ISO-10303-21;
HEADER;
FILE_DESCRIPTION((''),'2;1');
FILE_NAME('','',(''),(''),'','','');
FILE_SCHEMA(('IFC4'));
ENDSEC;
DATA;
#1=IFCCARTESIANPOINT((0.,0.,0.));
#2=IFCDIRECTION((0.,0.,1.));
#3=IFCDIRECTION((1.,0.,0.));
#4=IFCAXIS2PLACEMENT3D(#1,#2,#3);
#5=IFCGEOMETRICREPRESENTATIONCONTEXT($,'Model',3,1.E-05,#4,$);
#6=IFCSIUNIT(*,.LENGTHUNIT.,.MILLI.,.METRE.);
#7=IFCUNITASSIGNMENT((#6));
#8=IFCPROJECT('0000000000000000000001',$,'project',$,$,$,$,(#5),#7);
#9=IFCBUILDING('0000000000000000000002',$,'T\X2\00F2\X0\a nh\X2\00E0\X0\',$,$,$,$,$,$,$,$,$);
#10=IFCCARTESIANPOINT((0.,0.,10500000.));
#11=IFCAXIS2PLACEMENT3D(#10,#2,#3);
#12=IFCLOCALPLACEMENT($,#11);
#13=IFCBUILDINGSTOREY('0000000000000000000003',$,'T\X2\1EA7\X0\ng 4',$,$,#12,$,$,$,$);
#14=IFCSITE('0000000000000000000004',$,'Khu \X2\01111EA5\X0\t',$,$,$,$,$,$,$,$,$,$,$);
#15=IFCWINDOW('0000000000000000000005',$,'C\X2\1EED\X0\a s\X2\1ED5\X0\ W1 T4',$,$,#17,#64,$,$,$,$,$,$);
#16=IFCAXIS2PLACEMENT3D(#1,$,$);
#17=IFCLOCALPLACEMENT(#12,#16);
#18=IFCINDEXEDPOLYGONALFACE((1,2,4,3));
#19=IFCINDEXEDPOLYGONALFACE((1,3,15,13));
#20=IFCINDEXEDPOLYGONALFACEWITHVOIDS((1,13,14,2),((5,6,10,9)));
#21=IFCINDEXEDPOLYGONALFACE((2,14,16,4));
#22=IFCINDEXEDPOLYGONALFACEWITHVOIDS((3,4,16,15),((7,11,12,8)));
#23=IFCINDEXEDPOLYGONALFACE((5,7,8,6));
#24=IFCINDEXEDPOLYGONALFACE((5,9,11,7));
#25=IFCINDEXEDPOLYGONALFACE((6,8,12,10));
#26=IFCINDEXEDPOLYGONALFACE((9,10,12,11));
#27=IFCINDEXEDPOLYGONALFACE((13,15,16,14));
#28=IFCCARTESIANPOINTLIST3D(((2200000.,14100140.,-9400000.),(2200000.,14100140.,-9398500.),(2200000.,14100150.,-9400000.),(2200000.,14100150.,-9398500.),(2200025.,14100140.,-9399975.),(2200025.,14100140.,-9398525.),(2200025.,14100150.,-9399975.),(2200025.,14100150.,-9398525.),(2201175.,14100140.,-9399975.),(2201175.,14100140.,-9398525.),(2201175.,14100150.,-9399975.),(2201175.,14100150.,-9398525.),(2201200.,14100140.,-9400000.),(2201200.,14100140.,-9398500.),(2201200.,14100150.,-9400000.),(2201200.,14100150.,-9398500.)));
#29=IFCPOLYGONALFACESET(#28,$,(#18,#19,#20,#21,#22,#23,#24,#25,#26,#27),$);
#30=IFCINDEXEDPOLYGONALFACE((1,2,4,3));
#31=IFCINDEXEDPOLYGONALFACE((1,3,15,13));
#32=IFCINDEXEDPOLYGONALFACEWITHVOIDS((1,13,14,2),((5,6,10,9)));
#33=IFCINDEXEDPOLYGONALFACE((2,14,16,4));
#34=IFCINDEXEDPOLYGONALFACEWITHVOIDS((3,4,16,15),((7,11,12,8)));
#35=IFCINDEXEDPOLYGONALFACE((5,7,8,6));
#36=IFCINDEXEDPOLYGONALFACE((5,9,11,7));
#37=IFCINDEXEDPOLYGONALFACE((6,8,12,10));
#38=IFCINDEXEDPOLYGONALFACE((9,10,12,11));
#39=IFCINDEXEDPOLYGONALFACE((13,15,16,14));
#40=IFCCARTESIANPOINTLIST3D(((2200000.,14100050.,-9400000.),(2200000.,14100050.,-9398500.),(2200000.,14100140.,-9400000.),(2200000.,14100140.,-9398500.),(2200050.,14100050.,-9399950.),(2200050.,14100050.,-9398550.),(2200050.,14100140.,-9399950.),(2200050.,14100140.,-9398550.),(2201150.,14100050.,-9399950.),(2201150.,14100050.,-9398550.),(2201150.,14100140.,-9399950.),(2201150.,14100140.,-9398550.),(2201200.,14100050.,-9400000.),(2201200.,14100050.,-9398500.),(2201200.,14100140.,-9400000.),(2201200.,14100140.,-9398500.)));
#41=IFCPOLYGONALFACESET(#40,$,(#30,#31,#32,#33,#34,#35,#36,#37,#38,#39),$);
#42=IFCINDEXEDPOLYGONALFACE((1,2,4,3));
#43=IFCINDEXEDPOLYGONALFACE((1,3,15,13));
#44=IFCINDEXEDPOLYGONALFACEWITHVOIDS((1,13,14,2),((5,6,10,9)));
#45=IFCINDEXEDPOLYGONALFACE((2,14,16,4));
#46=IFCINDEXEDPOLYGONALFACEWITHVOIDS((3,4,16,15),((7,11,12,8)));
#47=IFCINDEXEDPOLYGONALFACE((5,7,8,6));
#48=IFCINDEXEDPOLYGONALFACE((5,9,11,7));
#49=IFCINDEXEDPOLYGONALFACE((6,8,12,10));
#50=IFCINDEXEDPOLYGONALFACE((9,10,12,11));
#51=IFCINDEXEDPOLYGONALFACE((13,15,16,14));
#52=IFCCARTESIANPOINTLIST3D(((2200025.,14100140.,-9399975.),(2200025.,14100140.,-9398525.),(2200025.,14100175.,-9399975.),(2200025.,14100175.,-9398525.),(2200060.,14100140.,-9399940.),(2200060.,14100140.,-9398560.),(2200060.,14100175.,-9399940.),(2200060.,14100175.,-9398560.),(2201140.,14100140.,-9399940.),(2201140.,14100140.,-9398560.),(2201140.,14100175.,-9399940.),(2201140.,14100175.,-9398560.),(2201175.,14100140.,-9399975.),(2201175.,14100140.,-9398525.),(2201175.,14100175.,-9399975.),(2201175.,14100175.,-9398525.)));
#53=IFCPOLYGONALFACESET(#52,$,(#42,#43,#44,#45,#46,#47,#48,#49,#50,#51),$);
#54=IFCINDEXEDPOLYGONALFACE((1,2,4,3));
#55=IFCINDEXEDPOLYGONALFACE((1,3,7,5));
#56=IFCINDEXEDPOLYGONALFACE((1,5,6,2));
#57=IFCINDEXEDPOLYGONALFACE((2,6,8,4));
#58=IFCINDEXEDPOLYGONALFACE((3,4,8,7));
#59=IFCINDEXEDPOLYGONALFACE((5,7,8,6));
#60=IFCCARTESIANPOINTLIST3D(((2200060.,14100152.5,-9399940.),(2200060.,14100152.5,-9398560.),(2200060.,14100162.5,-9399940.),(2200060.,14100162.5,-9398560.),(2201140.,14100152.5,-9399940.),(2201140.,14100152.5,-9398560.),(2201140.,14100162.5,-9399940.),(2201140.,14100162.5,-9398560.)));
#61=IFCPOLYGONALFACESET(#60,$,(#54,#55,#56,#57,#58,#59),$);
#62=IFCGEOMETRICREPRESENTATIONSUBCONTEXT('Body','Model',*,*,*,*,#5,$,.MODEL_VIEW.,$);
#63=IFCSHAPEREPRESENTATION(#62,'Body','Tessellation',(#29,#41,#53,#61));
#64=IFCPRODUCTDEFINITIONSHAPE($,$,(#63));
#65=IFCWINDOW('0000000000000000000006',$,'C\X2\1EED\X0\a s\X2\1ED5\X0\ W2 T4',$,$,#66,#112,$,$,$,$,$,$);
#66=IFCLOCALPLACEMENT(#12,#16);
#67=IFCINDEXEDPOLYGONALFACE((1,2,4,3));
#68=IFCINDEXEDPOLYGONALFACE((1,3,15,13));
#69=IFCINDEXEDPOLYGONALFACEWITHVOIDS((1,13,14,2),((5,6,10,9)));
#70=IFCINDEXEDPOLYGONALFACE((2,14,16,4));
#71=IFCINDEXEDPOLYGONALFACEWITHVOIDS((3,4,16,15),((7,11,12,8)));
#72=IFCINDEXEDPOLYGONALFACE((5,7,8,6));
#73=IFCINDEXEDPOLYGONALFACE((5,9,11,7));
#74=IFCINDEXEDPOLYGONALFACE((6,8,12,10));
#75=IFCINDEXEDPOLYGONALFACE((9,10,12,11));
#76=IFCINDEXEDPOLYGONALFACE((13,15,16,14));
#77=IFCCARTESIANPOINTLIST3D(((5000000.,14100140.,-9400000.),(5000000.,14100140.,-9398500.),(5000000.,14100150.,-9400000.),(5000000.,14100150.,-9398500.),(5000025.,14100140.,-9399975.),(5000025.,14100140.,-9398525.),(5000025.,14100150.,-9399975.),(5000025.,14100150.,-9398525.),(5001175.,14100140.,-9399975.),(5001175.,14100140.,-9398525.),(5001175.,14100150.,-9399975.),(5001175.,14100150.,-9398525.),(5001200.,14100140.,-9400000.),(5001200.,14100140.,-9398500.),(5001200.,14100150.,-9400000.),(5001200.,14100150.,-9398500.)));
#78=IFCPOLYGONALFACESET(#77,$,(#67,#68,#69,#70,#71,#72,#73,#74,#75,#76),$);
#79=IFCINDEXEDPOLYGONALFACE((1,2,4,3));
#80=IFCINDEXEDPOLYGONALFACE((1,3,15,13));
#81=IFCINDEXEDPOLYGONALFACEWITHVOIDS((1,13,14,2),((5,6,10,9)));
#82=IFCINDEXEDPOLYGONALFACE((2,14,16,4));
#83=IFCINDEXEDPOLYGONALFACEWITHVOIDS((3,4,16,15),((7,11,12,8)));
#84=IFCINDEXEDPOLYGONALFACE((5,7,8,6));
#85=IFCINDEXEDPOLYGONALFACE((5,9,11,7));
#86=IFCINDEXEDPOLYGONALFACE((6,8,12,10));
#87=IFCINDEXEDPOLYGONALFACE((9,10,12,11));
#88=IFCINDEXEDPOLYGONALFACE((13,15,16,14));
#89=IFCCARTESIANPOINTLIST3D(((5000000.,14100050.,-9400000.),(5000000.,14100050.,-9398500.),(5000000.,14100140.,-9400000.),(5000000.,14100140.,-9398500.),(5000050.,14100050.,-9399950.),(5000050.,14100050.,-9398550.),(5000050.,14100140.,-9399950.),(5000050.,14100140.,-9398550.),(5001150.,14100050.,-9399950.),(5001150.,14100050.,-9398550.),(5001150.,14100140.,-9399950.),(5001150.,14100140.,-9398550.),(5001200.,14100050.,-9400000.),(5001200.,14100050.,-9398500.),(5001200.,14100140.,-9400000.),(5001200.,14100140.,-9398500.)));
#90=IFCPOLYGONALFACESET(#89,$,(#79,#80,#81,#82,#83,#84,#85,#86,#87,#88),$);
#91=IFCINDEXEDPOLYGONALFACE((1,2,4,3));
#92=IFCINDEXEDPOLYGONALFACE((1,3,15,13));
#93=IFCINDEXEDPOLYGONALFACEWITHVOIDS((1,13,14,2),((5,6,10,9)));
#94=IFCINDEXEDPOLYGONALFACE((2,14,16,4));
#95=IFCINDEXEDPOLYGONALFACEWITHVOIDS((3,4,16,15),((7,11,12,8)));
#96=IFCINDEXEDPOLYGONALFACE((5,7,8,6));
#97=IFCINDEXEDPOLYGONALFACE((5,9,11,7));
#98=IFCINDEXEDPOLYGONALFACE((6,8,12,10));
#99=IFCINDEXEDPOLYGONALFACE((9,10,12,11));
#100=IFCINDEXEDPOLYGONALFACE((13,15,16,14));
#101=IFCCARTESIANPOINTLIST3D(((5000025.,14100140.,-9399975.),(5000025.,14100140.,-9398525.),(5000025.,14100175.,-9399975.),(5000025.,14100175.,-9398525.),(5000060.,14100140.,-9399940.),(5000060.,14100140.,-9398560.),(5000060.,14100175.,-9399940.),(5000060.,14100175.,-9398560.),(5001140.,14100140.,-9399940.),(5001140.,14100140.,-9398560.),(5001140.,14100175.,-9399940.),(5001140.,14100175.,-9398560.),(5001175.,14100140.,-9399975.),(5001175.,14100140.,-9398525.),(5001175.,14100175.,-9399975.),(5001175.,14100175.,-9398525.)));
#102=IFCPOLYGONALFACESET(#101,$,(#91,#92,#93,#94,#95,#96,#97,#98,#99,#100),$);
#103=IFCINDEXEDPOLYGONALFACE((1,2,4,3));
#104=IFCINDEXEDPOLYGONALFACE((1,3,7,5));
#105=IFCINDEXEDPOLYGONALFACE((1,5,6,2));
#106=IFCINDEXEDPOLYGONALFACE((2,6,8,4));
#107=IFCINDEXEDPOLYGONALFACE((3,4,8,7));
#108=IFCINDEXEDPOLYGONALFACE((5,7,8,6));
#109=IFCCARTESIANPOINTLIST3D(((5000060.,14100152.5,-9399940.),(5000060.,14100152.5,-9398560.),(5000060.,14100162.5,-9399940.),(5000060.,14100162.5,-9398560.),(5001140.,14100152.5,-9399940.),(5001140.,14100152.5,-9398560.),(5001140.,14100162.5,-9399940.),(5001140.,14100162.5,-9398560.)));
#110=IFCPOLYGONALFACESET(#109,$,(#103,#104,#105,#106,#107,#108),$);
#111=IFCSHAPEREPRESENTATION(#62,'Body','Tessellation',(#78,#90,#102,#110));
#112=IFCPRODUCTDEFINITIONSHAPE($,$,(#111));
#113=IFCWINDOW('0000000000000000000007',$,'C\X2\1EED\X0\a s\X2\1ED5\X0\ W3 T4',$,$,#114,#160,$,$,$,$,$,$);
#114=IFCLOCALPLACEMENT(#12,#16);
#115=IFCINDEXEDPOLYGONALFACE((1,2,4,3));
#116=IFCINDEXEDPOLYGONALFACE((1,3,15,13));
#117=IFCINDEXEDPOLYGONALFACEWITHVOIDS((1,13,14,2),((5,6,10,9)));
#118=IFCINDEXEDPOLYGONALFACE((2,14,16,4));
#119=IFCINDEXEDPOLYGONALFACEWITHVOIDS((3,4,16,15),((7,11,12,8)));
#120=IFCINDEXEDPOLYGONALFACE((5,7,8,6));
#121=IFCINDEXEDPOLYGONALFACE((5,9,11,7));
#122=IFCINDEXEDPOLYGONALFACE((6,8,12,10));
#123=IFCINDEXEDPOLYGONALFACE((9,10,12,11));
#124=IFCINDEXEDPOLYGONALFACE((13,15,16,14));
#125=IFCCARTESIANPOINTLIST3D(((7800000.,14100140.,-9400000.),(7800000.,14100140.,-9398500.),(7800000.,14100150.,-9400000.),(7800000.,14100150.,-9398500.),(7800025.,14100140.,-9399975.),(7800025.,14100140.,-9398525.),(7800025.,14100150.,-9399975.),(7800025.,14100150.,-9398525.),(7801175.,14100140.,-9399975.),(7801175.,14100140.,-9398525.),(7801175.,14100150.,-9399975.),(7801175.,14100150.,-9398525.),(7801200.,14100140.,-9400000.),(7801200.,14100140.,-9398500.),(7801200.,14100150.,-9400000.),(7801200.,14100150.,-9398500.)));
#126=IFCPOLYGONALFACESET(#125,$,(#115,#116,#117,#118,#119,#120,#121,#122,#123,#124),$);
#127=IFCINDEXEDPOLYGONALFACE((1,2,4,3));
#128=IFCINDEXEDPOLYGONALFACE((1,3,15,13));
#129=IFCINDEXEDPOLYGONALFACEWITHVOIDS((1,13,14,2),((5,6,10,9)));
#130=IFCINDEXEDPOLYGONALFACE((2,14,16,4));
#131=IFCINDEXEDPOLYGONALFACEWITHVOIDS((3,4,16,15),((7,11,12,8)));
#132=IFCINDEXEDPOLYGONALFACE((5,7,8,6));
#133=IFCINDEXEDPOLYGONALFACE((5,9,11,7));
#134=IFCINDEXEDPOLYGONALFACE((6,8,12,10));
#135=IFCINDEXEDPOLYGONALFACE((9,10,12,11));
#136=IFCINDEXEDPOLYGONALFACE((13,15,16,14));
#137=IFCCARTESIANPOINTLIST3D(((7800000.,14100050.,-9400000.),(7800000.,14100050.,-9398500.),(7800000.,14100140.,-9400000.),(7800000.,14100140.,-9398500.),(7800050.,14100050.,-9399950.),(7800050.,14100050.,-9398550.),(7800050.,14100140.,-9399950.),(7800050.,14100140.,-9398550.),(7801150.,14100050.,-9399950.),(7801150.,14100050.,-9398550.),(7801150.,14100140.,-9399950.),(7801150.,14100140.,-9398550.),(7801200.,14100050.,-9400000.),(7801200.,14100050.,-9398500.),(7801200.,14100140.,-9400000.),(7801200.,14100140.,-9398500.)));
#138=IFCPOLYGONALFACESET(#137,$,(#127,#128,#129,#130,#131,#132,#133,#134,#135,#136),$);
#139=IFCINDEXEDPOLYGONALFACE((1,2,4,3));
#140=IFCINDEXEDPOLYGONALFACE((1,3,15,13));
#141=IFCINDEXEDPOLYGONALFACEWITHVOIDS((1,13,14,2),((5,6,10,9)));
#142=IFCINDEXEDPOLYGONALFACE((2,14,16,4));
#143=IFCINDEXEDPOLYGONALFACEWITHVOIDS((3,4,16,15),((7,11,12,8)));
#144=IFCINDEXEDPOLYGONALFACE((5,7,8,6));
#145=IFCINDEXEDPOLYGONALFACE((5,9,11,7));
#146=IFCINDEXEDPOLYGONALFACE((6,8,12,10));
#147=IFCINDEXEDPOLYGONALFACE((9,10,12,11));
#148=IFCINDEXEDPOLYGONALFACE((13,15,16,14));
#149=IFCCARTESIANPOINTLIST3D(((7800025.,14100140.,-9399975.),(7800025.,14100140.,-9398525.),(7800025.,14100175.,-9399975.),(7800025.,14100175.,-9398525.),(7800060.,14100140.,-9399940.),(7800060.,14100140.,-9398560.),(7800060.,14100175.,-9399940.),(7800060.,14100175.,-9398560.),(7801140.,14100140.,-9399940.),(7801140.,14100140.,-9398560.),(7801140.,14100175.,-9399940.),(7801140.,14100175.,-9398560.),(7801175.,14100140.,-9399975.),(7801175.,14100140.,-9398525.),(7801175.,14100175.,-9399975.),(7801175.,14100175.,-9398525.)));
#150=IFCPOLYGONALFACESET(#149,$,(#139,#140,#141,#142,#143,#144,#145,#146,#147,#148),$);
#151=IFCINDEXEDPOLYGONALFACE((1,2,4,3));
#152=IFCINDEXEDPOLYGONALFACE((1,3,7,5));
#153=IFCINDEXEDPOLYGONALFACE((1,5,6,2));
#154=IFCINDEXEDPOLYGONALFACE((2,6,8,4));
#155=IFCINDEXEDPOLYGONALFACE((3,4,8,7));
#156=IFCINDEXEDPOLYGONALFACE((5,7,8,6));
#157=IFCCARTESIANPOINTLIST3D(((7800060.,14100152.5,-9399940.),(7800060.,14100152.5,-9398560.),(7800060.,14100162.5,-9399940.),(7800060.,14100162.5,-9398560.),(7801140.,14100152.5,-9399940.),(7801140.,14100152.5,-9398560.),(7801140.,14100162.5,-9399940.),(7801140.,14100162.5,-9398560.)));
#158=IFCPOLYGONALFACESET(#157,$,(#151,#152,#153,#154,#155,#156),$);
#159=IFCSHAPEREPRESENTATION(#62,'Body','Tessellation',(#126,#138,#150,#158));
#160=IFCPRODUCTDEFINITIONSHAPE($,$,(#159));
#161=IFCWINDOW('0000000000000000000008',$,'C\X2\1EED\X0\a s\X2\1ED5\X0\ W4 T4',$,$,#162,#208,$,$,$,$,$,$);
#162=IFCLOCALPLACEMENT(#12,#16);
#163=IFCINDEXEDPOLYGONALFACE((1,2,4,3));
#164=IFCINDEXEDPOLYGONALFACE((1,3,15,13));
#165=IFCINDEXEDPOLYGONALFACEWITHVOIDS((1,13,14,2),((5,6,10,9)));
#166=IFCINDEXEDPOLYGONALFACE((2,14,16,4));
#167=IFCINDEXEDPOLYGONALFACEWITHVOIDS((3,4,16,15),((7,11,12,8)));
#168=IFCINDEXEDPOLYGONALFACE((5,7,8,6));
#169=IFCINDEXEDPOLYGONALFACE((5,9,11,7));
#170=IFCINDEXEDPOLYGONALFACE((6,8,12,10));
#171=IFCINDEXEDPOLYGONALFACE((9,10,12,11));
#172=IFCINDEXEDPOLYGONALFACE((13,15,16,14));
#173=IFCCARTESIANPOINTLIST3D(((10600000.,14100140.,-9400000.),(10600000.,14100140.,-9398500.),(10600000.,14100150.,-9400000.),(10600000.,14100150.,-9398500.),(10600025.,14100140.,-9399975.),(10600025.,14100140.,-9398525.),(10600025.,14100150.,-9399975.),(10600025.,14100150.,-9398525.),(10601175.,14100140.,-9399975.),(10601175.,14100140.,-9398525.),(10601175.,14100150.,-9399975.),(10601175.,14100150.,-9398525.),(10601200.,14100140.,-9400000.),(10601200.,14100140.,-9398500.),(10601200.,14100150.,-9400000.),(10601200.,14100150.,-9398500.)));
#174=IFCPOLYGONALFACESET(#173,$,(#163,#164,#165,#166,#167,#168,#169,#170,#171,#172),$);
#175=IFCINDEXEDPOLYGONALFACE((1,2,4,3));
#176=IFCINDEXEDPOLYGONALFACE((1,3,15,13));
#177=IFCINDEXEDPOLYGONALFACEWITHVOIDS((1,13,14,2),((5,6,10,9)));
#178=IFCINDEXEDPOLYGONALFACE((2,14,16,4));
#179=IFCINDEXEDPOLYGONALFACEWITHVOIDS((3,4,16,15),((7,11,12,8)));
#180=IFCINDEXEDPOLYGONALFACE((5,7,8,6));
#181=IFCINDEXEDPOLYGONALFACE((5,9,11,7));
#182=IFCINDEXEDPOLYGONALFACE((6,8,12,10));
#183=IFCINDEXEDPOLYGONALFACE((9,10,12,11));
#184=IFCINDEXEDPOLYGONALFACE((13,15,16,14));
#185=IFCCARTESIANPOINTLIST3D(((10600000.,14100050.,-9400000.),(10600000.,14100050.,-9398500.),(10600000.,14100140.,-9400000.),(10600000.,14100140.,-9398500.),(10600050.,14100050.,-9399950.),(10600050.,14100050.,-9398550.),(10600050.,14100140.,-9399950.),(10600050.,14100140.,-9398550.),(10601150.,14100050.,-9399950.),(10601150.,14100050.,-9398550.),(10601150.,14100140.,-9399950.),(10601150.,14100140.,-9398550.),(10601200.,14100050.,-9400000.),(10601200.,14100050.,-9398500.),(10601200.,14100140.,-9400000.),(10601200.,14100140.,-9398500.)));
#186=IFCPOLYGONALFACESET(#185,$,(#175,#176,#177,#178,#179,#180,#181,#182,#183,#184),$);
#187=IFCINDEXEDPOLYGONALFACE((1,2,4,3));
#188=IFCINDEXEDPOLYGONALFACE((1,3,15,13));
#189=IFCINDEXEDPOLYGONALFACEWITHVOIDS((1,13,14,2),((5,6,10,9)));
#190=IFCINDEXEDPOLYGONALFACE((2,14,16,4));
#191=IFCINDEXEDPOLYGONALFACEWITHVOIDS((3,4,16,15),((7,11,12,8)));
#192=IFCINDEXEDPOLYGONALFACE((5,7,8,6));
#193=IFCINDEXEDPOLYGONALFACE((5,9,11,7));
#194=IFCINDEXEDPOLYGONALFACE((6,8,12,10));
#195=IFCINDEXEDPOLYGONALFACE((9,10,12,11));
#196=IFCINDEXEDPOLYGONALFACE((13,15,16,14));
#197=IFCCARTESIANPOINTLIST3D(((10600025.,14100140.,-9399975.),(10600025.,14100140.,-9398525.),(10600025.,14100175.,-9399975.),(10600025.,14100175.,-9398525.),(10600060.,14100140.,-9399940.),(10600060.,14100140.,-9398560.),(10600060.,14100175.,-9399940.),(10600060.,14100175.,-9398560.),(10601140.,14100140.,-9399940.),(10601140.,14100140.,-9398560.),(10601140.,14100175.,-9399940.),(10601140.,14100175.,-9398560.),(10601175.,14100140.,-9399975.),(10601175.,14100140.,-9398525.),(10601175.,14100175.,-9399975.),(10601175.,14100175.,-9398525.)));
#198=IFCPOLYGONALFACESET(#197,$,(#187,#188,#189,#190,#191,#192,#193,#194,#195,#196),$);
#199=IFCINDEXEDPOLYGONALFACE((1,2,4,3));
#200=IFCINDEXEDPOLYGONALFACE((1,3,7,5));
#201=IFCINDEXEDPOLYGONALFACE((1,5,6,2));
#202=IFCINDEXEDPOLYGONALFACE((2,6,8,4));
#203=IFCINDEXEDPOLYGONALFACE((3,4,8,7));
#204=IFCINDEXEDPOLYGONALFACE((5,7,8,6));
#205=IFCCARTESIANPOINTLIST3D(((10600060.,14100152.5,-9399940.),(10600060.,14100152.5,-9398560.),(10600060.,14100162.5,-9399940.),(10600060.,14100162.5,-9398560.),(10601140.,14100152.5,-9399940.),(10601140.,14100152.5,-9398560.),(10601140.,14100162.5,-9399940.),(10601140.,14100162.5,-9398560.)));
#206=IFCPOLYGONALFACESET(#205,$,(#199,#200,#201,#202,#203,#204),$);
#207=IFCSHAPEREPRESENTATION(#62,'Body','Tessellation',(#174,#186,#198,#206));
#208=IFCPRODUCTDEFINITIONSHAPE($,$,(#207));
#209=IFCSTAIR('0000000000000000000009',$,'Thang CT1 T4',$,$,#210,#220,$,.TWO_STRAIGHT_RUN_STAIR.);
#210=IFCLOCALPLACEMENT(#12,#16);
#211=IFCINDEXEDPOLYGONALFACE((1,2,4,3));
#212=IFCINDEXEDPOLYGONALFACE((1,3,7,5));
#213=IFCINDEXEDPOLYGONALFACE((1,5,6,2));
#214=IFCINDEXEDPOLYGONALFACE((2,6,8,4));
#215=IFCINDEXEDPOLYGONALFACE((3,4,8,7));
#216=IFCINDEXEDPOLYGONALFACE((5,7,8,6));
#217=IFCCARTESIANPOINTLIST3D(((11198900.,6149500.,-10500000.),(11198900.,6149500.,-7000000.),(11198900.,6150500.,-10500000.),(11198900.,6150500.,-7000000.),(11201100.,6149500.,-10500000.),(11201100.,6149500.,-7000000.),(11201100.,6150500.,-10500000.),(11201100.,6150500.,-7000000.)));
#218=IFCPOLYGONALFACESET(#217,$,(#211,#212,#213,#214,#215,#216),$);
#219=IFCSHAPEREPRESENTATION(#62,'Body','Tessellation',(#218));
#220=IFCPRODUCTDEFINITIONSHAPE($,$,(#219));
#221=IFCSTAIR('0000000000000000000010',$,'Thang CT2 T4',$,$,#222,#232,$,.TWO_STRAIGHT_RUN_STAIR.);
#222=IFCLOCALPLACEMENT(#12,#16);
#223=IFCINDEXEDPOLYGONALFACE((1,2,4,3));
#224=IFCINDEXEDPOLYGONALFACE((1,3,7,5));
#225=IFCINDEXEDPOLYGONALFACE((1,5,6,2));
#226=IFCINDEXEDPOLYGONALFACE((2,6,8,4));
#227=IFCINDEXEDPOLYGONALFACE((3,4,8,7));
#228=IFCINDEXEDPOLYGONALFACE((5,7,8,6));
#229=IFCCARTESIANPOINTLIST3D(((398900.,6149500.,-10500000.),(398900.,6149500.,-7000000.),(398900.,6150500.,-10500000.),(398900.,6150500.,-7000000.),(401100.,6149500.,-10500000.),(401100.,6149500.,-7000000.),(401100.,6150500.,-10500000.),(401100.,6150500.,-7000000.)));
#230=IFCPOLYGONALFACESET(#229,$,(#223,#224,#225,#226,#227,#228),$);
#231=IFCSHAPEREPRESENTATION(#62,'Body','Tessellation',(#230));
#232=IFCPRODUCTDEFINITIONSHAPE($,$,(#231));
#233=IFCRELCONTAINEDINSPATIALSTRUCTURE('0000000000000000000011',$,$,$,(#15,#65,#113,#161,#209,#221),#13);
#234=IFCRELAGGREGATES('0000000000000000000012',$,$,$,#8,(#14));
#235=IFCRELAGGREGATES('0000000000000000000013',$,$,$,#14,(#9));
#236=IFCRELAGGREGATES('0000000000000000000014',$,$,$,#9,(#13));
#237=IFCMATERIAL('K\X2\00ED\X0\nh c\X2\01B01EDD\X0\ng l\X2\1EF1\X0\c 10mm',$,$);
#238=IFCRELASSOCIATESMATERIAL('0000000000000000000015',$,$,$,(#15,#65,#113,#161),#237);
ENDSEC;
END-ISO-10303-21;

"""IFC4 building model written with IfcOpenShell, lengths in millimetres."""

from ifc_helpers import new_model, entity, si_unit, frame, origin_with_axes, place, context, subcontext, project, spatial, line, indexed_curve, outline, extrude, material, element, save


model = new_model("IFC4")

# Units and contexts
model_context = context("Model", 3, precision=1e-05, world=origin_with_axes())
body_context = subcontext(model_context, "Body", "Model", "MODEL_VIEW")
ifc_project = project(units=[si_unit("LENGTHUNIT", "METRE", prefix="MILLI")], contexts=[model_context])

# Site, building, storey
site = spatial("IfcSite", under=ifc_project, Name="Khu đất")
building = spatial("IfcBuilding", under=site, Name="Tòa nhà")
storey_placement = place(None, frame((0.0, 0.0, 10500000.0), z_axis=(0.0, 0.0, 1.0), x_axis=(1.0, 0.0, 0.0)))
storey = spatial("IfcBuildingStorey", under=building, at=storey_placement, Name="Tầng 4")

# Windows
ifc_material_1 = material(Name="Kính cường lực 10mm")
for number, where, z_axis, x_axis, name in (
    (1, (2200000.0, 14100000.0, -9400000.0), (0.0, 0.0, 1.0), (1.0, 0.0, 0.0), "Cửa sổ W1 T4"),
    (2, (5000000.0, 14100000.0, -9400000.0), (0.0, 0.0, 1.0), (1.0, 0.0, 0.0), "Cửa sổ W2 T4"),
    (3, (7800000.0, 14100000.0, -9400000.0), (0.0, 0.0, 1.0), (1.0, 0.0, 0.0), "Cửa sổ W3 T4"),
    (4, (10600000.0, 14100000.0, -9400000.0), (0.0, 0.0, 1.0), (1.0, 0.0, 0.0), "Cửa sổ W4 T4"),
):
    element("IfcWindow", number, at=place(storey_placement, frame(where, z_axis=z_axis, x_axis=x_axis)), inside=storey, material=ifc_material_1, Name=name, context=body_context, shape_type="SolidModel", body=[
        extrude(outline(indexed_curve([(0.0, 0.0), (1200.0, 0.0), (1200.0, 1500.0), (0.0, 1500.0)], segments=[line(1, 2, 3, 4, 1)]), holes=[indexed_curve([(25.0, 25.0), (1175.0, 25.0), (1175.0, 1475.0), (25.0, 1475.0)], segments=[line(1, 2, 3, 4, 1)])]), frame((0.0, 140.0, 0.0), z_axis=(0.0, -1.0, 0.0), x_axis=(1.0, 0.0, 0.0)), (0.0, 0.0, -1.0), 10.0),
        extrude(outline(indexed_curve([(0.0, 0.0), (1200.0, 0.0), (1200.0, 1500.0), (0.0, 1500.0)], segments=[line(1, 2, 3, 4, 1)]), holes=[indexed_curve([(50.0, 50.0), (1150.0, 50.0), (1150.0, 1450.0), (50.0, 1450.0)], segments=[line(1, 2, 3, 4, 1)])]), frame((0.0, 50.0, 0.0), z_axis=(0.0, -1.0, 0.0), x_axis=(1.0, 0.0, 0.0)), (0.0, 0.0, -1.0), 90.0),
        extrude(outline(indexed_curve([(0.0, 0.0), (1150.0, 0.0), (1150.0, 1450.0), (0.0, 1450.0)], segments=[line(1, 2, 3, 4, 1)]), holes=[indexed_curve([(35.0, 35.0), (1115.0, 35.0), (1115.0, 1415.0), (35.0, 1415.0)], segments=[line(1, 2, 3, 4, 1)])]), frame((25.0, 140.0, 25.0), z_axis=(0.0, -1.0, 0.0), x_axis=(1.0, 0.0, 0.0)), (0.0, 0.0, -1.0), 35.0),
        extrude(outline(indexed_curve([(35.0, 35.0), (1115.0, 35.0), (1115.0, 1415.0), (35.0, 1415.0)], segments=[line(1, 2, 3, 4, 1)])), frame((25.0, 152.5, 25.0), z_axis=(0.0, -1.0, 0.0), x_axis=(1.0, 0.0, 0.0)), (0.0, 0.0, -1.0), 10.0),
    ])

# Stairs
for number, where, z_axis, x_axis, name in (
    (5, (11200000.0, 6150000.0, -10500000.0), (0.0, 0.0, 1.0), (1.0, 0.0, 0.0), "Thang CT1 T4"),
    (6, (400000.0, 6150000.0, -10500000.0), (0.0, 0.0, 1.0), (1.0, 0.0, 0.0), "Thang CT2 T4"),
):
    element("IfcStair", number, at=place(storey_placement, frame(where, z_axis=z_axis, x_axis=x_axis)), inside=storey, Name=name, PredefinedType="TWO_STRAIGHT_RUN_STAIR", context=body_context, shape_type="SweptSolid", body=[
        extrude(entity("IfcRectangleProfileDef", None, None, None, 2200.0, 1000.0), origin_with_axes(), (0.0, 0.0, 1.0), 3500000.0),
    ])

save(model, "model.ifc")
